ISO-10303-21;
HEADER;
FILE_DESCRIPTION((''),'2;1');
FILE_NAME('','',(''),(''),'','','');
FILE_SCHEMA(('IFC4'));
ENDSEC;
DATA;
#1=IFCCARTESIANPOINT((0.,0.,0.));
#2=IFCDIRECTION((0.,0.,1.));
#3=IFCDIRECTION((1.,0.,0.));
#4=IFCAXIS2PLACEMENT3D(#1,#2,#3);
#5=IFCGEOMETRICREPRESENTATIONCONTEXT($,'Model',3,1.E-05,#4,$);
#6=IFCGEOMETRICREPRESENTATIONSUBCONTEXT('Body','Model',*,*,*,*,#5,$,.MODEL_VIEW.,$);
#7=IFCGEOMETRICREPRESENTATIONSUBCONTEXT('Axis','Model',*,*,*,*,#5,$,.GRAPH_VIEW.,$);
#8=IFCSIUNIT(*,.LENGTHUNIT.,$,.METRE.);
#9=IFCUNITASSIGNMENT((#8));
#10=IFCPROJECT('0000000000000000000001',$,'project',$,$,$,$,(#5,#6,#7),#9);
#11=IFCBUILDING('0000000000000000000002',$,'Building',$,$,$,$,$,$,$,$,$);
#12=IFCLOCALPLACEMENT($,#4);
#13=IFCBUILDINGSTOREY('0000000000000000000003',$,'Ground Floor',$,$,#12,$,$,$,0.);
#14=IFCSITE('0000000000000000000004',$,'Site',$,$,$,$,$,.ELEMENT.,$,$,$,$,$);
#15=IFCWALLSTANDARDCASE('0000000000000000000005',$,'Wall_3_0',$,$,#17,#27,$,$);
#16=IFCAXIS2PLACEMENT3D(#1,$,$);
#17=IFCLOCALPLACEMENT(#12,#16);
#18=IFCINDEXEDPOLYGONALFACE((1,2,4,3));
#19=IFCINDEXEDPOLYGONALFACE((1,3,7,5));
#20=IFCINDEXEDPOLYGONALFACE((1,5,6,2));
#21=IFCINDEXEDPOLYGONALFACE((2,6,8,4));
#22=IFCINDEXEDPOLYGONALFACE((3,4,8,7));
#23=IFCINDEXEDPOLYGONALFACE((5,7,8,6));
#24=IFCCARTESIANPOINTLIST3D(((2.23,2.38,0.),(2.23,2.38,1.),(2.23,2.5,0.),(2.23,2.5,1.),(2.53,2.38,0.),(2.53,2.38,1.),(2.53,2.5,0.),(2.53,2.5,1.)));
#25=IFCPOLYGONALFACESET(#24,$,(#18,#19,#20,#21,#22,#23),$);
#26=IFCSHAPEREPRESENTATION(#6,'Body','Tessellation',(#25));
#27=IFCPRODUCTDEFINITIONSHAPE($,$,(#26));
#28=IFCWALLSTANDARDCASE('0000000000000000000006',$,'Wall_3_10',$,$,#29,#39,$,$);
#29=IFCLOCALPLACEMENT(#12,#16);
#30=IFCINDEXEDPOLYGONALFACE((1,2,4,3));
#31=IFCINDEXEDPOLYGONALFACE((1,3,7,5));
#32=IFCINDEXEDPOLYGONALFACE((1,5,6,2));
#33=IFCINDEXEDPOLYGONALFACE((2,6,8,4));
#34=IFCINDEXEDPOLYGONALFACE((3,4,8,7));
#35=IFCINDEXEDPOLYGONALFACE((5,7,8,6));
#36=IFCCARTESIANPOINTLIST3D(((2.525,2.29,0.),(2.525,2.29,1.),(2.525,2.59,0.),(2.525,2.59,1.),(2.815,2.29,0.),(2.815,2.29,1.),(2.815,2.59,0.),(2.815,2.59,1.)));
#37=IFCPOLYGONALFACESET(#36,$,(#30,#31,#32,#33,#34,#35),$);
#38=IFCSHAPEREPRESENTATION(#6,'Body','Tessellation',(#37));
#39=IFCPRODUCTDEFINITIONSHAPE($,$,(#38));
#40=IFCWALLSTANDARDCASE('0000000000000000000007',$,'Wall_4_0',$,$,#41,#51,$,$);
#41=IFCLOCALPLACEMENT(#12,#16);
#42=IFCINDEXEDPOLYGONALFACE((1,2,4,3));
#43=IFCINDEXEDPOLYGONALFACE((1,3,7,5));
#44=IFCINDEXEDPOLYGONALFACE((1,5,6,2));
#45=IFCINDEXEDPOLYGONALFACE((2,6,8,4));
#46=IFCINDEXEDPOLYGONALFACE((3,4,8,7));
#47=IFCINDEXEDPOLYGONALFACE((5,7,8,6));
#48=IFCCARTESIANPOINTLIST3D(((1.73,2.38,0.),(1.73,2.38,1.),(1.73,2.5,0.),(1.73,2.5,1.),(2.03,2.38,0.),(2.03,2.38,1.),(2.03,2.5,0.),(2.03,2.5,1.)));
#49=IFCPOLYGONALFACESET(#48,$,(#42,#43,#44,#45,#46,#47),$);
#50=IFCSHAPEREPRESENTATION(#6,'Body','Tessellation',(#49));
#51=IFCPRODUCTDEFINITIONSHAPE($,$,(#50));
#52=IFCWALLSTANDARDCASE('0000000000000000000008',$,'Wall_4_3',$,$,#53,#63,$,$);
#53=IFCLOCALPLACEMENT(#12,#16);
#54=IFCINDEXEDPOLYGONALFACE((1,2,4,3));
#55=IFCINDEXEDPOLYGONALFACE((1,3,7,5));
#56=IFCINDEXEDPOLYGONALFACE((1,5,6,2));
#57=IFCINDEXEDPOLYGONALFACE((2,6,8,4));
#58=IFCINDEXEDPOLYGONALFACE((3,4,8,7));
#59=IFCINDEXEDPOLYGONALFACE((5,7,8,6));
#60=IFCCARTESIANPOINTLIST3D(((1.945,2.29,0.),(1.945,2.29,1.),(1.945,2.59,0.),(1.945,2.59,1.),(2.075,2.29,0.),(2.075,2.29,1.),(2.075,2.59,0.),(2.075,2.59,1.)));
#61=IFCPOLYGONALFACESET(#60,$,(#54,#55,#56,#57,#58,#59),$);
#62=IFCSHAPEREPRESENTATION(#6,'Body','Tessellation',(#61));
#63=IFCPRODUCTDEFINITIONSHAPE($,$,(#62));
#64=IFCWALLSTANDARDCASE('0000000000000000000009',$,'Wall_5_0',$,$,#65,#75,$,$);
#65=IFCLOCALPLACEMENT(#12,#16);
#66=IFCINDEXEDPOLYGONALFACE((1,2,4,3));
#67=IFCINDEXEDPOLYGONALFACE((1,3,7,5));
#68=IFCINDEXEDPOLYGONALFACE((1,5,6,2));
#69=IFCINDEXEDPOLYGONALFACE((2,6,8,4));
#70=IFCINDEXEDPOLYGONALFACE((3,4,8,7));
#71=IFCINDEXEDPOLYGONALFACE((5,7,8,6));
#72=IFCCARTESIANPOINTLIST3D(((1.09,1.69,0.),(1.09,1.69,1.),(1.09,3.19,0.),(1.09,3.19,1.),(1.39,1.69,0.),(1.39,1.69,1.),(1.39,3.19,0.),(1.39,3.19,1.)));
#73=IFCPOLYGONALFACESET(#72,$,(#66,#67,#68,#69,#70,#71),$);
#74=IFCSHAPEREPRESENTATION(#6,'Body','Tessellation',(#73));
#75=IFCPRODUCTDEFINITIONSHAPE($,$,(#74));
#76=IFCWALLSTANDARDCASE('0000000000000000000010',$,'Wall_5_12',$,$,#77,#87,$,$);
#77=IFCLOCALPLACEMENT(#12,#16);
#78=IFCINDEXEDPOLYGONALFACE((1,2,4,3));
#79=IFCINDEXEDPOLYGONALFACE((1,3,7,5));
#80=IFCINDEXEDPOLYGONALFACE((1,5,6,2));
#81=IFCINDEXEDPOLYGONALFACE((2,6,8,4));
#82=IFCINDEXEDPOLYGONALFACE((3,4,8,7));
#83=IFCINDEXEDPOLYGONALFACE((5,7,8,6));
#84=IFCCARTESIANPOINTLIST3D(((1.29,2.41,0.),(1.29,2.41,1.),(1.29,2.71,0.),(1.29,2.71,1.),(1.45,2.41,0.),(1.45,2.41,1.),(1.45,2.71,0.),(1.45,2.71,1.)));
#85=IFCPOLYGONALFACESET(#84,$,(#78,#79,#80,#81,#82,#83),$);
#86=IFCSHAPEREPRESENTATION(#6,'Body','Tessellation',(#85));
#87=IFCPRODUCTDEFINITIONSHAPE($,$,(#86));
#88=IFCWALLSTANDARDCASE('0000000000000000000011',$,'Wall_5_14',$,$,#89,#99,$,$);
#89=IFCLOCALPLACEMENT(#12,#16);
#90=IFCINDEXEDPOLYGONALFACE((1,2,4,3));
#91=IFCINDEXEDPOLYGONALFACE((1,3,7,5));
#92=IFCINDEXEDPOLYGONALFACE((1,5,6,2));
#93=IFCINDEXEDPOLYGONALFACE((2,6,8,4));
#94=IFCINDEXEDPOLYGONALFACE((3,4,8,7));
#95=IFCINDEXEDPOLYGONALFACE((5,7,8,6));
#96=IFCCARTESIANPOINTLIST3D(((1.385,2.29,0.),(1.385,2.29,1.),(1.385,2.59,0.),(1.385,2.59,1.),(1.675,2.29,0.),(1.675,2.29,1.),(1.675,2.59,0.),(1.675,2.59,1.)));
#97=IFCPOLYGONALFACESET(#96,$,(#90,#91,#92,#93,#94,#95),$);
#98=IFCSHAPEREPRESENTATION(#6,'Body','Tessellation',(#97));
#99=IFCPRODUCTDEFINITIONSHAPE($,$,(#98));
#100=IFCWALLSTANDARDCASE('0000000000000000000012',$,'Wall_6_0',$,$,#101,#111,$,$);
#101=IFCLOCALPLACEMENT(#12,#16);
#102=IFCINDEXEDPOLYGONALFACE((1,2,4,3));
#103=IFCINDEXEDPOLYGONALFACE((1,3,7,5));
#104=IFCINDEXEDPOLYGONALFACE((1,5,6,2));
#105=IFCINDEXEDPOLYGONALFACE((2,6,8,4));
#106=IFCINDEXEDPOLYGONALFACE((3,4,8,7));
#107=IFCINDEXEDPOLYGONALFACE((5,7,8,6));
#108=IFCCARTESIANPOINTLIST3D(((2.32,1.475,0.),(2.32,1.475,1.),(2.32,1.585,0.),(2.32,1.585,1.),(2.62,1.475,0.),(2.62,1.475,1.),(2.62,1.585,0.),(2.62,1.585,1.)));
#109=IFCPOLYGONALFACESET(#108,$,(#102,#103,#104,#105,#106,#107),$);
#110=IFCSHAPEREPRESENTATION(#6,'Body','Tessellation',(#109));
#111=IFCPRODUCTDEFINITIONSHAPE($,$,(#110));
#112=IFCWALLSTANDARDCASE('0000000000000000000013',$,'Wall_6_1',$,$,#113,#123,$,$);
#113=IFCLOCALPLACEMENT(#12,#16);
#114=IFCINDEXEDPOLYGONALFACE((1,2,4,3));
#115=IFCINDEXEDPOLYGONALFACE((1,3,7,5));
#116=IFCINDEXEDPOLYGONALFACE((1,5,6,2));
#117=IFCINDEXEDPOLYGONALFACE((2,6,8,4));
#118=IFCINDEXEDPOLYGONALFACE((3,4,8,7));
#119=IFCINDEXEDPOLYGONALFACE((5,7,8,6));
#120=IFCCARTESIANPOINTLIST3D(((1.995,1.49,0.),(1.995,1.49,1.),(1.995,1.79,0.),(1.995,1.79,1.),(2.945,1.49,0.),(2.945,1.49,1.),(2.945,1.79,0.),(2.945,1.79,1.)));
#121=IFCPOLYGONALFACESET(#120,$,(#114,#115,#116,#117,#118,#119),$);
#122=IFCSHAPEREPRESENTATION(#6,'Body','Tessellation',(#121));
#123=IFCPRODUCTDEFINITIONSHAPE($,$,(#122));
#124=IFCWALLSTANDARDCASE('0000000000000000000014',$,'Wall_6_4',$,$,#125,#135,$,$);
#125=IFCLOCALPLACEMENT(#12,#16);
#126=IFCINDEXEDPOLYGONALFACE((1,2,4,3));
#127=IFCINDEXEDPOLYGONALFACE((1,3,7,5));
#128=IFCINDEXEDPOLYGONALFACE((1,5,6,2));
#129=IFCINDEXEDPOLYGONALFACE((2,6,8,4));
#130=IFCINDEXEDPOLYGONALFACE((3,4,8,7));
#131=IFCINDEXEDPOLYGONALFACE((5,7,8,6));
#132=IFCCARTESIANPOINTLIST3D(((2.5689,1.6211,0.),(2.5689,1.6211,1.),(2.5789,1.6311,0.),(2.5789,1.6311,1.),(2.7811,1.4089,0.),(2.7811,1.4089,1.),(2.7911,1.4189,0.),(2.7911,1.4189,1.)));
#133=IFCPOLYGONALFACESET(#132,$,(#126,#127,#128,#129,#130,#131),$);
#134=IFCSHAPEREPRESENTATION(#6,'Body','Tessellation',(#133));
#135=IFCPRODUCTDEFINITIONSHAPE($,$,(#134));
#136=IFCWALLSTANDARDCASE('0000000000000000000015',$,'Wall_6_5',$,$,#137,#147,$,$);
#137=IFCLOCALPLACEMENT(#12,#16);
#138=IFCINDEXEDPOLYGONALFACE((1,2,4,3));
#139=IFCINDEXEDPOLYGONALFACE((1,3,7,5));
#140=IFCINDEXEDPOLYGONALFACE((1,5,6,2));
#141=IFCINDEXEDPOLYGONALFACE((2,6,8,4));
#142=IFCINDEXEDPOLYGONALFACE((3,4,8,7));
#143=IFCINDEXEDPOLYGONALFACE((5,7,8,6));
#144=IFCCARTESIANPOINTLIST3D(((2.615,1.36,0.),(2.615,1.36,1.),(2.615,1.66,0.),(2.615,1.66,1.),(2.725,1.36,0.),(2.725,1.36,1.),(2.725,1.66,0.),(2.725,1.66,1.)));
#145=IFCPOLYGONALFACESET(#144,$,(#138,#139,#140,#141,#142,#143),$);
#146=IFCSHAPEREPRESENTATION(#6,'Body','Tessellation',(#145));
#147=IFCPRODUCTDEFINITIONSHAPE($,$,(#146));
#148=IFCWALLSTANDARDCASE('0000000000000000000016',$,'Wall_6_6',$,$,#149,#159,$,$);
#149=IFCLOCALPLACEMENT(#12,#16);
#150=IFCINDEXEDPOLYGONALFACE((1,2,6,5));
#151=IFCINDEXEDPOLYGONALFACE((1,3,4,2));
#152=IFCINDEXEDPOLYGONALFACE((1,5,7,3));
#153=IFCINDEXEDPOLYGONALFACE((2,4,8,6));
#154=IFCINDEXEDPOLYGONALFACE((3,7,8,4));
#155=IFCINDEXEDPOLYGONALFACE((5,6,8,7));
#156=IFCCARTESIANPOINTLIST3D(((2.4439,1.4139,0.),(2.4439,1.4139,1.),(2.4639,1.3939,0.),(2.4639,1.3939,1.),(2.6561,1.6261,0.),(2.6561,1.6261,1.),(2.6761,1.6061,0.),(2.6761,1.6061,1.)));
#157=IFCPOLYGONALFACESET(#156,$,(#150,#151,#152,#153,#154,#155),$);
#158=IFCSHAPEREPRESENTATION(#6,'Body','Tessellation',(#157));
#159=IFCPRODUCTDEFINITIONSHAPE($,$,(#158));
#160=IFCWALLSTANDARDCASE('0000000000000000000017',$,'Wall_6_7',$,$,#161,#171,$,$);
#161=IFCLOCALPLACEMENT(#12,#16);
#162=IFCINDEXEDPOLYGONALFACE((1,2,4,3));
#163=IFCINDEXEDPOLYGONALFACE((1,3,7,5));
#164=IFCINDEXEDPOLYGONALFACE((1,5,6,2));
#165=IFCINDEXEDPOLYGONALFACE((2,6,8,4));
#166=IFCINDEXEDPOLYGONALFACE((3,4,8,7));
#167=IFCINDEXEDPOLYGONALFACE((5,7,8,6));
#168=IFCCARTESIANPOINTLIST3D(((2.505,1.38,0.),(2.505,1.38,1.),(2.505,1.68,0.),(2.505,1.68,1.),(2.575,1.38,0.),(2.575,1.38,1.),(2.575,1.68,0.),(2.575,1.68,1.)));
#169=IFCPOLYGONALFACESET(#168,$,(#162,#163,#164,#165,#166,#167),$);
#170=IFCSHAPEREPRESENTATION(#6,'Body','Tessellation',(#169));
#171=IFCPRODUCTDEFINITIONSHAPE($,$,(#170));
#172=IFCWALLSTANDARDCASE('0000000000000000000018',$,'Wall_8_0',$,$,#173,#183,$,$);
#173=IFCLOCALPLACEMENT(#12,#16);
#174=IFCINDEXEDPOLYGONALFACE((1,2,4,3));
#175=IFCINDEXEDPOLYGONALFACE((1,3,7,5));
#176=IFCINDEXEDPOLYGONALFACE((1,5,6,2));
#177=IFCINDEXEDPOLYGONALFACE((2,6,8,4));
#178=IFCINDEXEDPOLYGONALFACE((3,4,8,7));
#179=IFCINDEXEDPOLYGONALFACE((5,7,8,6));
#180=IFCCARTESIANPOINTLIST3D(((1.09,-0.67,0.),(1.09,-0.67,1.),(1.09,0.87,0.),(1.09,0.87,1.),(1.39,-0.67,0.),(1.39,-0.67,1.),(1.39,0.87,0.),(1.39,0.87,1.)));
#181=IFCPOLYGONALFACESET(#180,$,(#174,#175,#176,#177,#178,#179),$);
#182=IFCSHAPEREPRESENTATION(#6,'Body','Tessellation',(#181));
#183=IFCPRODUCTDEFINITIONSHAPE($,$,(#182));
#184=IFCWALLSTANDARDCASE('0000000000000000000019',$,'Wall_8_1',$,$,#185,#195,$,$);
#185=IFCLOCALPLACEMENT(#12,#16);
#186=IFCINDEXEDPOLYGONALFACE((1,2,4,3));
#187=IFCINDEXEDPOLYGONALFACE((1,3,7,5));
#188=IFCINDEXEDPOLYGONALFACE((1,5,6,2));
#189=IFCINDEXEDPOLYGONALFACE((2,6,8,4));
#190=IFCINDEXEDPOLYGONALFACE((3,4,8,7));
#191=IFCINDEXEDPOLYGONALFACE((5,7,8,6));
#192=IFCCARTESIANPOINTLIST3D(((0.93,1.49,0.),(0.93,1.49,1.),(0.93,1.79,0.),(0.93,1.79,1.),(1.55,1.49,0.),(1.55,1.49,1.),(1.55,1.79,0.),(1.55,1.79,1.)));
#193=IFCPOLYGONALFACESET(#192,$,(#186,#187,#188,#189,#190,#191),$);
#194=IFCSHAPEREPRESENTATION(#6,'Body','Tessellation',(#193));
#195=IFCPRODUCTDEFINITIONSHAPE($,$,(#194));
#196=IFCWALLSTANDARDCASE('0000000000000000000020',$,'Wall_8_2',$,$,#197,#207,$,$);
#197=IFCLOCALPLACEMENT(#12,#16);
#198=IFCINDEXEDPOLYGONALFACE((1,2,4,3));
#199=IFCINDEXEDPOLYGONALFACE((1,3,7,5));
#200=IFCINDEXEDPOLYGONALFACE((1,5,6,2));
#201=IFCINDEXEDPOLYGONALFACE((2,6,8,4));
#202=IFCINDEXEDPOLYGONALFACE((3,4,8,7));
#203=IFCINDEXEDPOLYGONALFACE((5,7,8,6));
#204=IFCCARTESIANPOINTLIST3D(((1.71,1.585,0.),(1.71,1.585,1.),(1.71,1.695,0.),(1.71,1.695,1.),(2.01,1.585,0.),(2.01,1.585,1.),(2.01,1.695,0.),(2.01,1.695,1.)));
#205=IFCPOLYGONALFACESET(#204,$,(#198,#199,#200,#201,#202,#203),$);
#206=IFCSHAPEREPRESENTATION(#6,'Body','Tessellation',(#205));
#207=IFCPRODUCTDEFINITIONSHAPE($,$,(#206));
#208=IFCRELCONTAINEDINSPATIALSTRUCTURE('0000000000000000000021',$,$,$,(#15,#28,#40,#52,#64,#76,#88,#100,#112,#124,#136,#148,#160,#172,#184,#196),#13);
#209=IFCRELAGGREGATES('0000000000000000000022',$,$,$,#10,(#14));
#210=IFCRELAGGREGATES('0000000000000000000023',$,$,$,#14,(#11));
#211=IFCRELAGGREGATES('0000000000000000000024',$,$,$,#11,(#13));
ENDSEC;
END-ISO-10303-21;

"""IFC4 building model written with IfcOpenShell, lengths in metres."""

from ifc_helpers import new_model, si_unit, frame, origin_with_axes, origin_2d, place, context, subcontext, project, spatial, rectangle, extrude, element, save


model = new_model("IFC4")

# Units and contexts
model_context = context("Model", 3, precision=1e-05, world=origin_with_axes())
body_context = subcontext(model_context, "Body", "Model", "MODEL_VIEW")
axis_context = subcontext(model_context, "Axis", "Model", "GRAPH_VIEW")
ifc_project = project(units=[si_unit("LENGTHUNIT", "METRE")], contexts=[model_context, body_context, axis_context])

# Site, building, storey
site = spatial("IfcSite", under=ifc_project, Name="Site", CompositionType="ELEMENT")
building = spatial("IfcBuilding", under=site, Name="Building")
storey_placement = place(None, origin_with_axes())
storey = spatial("IfcBuildingStorey", under=building, at=storey_placement, Name="Ground Floor", Elevation=0.0)

# Walls
wall_1_placement = place(storey_placement, frame((2.38, 2.44, 0.0), z_axis=(0.0, 0.0, 1.0), x_axis=(0.0, 1.0, 0.0)))
element("IfcWallStandardCase", 1, at=wall_1_placement, inside=storey, Name="Wall_3_0", context=body_context, shape_type="SweptSolid", body=[
    extrude(rectangle(XDim=0.12, YDim=0.3, at=origin_2d()), origin_with_axes(), (0.0, 0.0, 1.0), 1.0),
])
wall_2_placement = place(storey_placement, frame((2.67, 2.44, 0.0), z_axis=(0.0, 0.0, 1.0), x_axis=(-1.0, 0.0, 0.0)))
element("IfcWallStandardCase", 2, at=wall_2_placement, inside=storey, Name="Wall_3_10", context=body_context, shape_type="SweptSolid", body=[
    extrude(rectangle(XDim=0.29, YDim=0.3, at=origin_2d()), origin_with_axes(), (0.0, 0.0, 1.0), 1.0),
])
wall_3_placement = place(storey_placement, frame((1.88, 2.44, 0.0), z_axis=(0.0, 0.0, 1.0), x_axis=(0.0, 1.0, 0.0)))
element("IfcWallStandardCase", 3, at=wall_3_placement, inside=storey, Name="Wall_4_0", context=body_context, shape_type="SweptSolid", body=[
    extrude(rectangle(XDim=0.12, YDim=0.3, at=origin_2d()), origin_with_axes(), (0.0, 0.0, 1.0), 1.0),
])
wall_4_placement = place(storey_placement, frame((2.01, 2.44, 0.0), z_axis=(0.0, 0.0, 1.0), x_axis=(-1.0, 0.0, 0.0)))
element("IfcWallStandardCase", 4, at=wall_4_placement, inside=storey, Name="Wall_4_3", context=body_context, shape_type="SweptSolid", body=[
    extrude(rectangle(XDim=0.13, YDim=0.3, at=origin_2d()), origin_with_axes(), (0.0, 0.0, 1.0), 1.0),
])
wall_5_placement = place(storey_placement, frame((1.24, 2.44, 0.0), z_axis=(0.0, 0.0, 1.0), x_axis=(0.0, 1.0, 0.0)))
element("IfcWallStandardCase", 5, at=wall_5_placement, inside=storey, Name="Wall_5_0", context=body_context, shape_type="SweptSolid", body=[
    extrude(rectangle(XDim=1.5, YDim=0.3, at=origin_2d()), origin_with_axes(), (0.0, 0.0, 1.0), 1.0),
])
wall_6_placement = place(storey_placement, frame((1.37, 2.56, 0.0), z_axis=(0.0, 0.0, 1.0), x_axis=(1.0, 0.0, 0.0)))
element("IfcWallStandardCase", 6, at=wall_6_placement, inside=storey, Name="Wall_5_12", context=body_context, shape_type="SweptSolid", body=[
    extrude(rectangle(XDim=0.16, YDim=0.3, at=origin_2d()), origin_with_axes(), (0.0, 0.0, 1.0), 1.0),
])
wall_7_placement = place(storey_placement, frame((1.53, 2.44, 0.0), z_axis=(0.0, 0.0, 1.0), x_axis=(-1.0, 0.0, 0.0)))
element("IfcWallStandardCase", 7, at=wall_7_placement, inside=storey, Name="Wall_5_14", context=body_context, shape_type="SweptSolid", body=[
    extrude(rectangle(XDim=0.29, YDim=0.3, at=origin_2d()), origin_with_axes(), (0.0, 0.0, 1.0), 1.0),
])
wall_8_placement = place(storey_placement, frame((2.47, 1.53, 0.0), z_axis=(0.0, 0.0, 1.0), x_axis=(0.0, 1.0, 0.0)))
element("IfcWallStandardCase", 8, at=wall_8_placement, inside=storey, Name="Wall_6_0", context=body_context, shape_type="SweptSolid", body=[
    extrude(rectangle(XDim=0.11, YDim=0.3, at=origin_2d()), origin_with_axes(), (0.0, 0.0, 1.0), 1.0),
])
wall_9_placement = place(storey_placement, frame((2.47, 1.64, 0.0), z_axis=(0.0, 0.0, 1.0), x_axis=(1.0, 0.0, 0.0)))
element("IfcWallStandardCase", 9, at=wall_9_placement, inside=storey, Name="Wall_6_1", context=body_context, shape_type="SweptSolid", body=[
    extrude(rectangle(XDim=0.95, YDim=0.3, at=origin_2d()), origin_with_axes(), (0.0, 0.0, 1.0), 1.0),
])
wall_10_placement = place(storey_placement, frame((2.68, 1.52, 0.0), z_axis=(0.0, 0.0, 1.0), x_axis=(-0.707107, -0.707107, 0.0)))
element("IfcWallStandardCase", 10, at=wall_10_placement, inside=storey, Name="Wall_6_4", context=body_context, shape_type="SweptSolid", body=[
    extrude(rectangle(XDim=0.0141, YDim=0.3, at=origin_2d()), origin_with_axes(), (0.0, 0.0, 1.0), 1.0),
])
wall_11_placement = place(storey_placement, frame((2.67, 1.51, 0.0), z_axis=(0.0, 0.0, 1.0), x_axis=(-1.0, 0.0, 0.0)))
element("IfcWallStandardCase", 11, at=wall_11_placement, inside=storey, Name="Wall_6_5", context=body_context, shape_type="SweptSolid", body=[
    extrude(rectangle(XDim=0.11, YDim=0.3, at=origin_2d()), origin_with_axes(), (0.0, 0.0, 1.0), 1.0),
])
wall_12_placement = place(storey_placement, frame((2.56, 1.51, 0.0), z_axis=(0.0, 0.0, 1.0), x_axis=(-0.707107, 0.707107, 0.0)))
element("IfcWallStandardCase", 12, at=wall_12_placement, inside=storey, Name="Wall_6_6", context=body_context, shape_type="SweptSolid", body=[
    extrude(rectangle(XDim=0.0283, YDim=0.3, at=origin_2d()), origin_with_axes(), (0.0, 0.0, 1.0), 1.0),
])
wall_13_placement = place(storey_placement, frame((2.54, 1.53, 0.0), z_axis=(0.0, 0.0, 1.0), x_axis=(-1.0, 0.0, 0.0)))
element("IfcWallStandardCase", 13, at=wall_13_placement, inside=storey, Name="Wall_6_7", context=body_context, shape_type="SweptSolid", body=[
    extrude(rectangle(XDim=0.07, YDim=0.3, at=origin_2d()), origin_with_axes(), (0.0, 0.0, 1.0), 1.0),
])
wall_14_placement = place(storey_placement, frame((1.24, 0.1, 0.0), z_axis=(0.0, 0.0, 1.0), x_axis=(0.0, 1.0, 0.0)))
element("IfcWallStandardCase", 14, at=wall_14_placement, inside=storey, Name="Wall_8_0", context=body_context, shape_type="SweptSolid", body=[
    extrude(rectangle(XDim=1.54, YDim=0.3, at=origin_2d()), origin_with_axes(), (0.0, 0.0, 1.0), 1.0),
])
wall_15_placement = place(storey_placement, frame((1.24, 1.64, 0.0), z_axis=(0.0, 0.0, 1.0), x_axis=(1.0, 0.0, 0.0)))
element("IfcWallStandardCase", 15, at=wall_15_placement, inside=storey, Name="Wall_8_1", context=body_context, shape_type="SweptSolid", body=[
    extrude(rectangle(XDim=0.62, YDim=0.3, at=origin_2d()), origin_with_axes(), (0.0, 0.0, 1.0), 1.0),
])
wall_16_placement = place(storey_placement, frame((1.86, 1.64, 0.0), z_axis=(0.0, 0.0, 1.0), x_axis=(0.0, -1.0, 0.0)))
element("IfcWallStandardCase", 16, at=wall_16_placement, inside=storey, Name="Wall_8_2", context=body_context, shape_type="SweptSolid", body=[
    extrude(rectangle(XDim=0.11, YDim=0.3, at=origin_2d()), origin_with_axes(), (0.0, 0.0, 1.0), 1.0),
])

save(model, "model.ifc")
